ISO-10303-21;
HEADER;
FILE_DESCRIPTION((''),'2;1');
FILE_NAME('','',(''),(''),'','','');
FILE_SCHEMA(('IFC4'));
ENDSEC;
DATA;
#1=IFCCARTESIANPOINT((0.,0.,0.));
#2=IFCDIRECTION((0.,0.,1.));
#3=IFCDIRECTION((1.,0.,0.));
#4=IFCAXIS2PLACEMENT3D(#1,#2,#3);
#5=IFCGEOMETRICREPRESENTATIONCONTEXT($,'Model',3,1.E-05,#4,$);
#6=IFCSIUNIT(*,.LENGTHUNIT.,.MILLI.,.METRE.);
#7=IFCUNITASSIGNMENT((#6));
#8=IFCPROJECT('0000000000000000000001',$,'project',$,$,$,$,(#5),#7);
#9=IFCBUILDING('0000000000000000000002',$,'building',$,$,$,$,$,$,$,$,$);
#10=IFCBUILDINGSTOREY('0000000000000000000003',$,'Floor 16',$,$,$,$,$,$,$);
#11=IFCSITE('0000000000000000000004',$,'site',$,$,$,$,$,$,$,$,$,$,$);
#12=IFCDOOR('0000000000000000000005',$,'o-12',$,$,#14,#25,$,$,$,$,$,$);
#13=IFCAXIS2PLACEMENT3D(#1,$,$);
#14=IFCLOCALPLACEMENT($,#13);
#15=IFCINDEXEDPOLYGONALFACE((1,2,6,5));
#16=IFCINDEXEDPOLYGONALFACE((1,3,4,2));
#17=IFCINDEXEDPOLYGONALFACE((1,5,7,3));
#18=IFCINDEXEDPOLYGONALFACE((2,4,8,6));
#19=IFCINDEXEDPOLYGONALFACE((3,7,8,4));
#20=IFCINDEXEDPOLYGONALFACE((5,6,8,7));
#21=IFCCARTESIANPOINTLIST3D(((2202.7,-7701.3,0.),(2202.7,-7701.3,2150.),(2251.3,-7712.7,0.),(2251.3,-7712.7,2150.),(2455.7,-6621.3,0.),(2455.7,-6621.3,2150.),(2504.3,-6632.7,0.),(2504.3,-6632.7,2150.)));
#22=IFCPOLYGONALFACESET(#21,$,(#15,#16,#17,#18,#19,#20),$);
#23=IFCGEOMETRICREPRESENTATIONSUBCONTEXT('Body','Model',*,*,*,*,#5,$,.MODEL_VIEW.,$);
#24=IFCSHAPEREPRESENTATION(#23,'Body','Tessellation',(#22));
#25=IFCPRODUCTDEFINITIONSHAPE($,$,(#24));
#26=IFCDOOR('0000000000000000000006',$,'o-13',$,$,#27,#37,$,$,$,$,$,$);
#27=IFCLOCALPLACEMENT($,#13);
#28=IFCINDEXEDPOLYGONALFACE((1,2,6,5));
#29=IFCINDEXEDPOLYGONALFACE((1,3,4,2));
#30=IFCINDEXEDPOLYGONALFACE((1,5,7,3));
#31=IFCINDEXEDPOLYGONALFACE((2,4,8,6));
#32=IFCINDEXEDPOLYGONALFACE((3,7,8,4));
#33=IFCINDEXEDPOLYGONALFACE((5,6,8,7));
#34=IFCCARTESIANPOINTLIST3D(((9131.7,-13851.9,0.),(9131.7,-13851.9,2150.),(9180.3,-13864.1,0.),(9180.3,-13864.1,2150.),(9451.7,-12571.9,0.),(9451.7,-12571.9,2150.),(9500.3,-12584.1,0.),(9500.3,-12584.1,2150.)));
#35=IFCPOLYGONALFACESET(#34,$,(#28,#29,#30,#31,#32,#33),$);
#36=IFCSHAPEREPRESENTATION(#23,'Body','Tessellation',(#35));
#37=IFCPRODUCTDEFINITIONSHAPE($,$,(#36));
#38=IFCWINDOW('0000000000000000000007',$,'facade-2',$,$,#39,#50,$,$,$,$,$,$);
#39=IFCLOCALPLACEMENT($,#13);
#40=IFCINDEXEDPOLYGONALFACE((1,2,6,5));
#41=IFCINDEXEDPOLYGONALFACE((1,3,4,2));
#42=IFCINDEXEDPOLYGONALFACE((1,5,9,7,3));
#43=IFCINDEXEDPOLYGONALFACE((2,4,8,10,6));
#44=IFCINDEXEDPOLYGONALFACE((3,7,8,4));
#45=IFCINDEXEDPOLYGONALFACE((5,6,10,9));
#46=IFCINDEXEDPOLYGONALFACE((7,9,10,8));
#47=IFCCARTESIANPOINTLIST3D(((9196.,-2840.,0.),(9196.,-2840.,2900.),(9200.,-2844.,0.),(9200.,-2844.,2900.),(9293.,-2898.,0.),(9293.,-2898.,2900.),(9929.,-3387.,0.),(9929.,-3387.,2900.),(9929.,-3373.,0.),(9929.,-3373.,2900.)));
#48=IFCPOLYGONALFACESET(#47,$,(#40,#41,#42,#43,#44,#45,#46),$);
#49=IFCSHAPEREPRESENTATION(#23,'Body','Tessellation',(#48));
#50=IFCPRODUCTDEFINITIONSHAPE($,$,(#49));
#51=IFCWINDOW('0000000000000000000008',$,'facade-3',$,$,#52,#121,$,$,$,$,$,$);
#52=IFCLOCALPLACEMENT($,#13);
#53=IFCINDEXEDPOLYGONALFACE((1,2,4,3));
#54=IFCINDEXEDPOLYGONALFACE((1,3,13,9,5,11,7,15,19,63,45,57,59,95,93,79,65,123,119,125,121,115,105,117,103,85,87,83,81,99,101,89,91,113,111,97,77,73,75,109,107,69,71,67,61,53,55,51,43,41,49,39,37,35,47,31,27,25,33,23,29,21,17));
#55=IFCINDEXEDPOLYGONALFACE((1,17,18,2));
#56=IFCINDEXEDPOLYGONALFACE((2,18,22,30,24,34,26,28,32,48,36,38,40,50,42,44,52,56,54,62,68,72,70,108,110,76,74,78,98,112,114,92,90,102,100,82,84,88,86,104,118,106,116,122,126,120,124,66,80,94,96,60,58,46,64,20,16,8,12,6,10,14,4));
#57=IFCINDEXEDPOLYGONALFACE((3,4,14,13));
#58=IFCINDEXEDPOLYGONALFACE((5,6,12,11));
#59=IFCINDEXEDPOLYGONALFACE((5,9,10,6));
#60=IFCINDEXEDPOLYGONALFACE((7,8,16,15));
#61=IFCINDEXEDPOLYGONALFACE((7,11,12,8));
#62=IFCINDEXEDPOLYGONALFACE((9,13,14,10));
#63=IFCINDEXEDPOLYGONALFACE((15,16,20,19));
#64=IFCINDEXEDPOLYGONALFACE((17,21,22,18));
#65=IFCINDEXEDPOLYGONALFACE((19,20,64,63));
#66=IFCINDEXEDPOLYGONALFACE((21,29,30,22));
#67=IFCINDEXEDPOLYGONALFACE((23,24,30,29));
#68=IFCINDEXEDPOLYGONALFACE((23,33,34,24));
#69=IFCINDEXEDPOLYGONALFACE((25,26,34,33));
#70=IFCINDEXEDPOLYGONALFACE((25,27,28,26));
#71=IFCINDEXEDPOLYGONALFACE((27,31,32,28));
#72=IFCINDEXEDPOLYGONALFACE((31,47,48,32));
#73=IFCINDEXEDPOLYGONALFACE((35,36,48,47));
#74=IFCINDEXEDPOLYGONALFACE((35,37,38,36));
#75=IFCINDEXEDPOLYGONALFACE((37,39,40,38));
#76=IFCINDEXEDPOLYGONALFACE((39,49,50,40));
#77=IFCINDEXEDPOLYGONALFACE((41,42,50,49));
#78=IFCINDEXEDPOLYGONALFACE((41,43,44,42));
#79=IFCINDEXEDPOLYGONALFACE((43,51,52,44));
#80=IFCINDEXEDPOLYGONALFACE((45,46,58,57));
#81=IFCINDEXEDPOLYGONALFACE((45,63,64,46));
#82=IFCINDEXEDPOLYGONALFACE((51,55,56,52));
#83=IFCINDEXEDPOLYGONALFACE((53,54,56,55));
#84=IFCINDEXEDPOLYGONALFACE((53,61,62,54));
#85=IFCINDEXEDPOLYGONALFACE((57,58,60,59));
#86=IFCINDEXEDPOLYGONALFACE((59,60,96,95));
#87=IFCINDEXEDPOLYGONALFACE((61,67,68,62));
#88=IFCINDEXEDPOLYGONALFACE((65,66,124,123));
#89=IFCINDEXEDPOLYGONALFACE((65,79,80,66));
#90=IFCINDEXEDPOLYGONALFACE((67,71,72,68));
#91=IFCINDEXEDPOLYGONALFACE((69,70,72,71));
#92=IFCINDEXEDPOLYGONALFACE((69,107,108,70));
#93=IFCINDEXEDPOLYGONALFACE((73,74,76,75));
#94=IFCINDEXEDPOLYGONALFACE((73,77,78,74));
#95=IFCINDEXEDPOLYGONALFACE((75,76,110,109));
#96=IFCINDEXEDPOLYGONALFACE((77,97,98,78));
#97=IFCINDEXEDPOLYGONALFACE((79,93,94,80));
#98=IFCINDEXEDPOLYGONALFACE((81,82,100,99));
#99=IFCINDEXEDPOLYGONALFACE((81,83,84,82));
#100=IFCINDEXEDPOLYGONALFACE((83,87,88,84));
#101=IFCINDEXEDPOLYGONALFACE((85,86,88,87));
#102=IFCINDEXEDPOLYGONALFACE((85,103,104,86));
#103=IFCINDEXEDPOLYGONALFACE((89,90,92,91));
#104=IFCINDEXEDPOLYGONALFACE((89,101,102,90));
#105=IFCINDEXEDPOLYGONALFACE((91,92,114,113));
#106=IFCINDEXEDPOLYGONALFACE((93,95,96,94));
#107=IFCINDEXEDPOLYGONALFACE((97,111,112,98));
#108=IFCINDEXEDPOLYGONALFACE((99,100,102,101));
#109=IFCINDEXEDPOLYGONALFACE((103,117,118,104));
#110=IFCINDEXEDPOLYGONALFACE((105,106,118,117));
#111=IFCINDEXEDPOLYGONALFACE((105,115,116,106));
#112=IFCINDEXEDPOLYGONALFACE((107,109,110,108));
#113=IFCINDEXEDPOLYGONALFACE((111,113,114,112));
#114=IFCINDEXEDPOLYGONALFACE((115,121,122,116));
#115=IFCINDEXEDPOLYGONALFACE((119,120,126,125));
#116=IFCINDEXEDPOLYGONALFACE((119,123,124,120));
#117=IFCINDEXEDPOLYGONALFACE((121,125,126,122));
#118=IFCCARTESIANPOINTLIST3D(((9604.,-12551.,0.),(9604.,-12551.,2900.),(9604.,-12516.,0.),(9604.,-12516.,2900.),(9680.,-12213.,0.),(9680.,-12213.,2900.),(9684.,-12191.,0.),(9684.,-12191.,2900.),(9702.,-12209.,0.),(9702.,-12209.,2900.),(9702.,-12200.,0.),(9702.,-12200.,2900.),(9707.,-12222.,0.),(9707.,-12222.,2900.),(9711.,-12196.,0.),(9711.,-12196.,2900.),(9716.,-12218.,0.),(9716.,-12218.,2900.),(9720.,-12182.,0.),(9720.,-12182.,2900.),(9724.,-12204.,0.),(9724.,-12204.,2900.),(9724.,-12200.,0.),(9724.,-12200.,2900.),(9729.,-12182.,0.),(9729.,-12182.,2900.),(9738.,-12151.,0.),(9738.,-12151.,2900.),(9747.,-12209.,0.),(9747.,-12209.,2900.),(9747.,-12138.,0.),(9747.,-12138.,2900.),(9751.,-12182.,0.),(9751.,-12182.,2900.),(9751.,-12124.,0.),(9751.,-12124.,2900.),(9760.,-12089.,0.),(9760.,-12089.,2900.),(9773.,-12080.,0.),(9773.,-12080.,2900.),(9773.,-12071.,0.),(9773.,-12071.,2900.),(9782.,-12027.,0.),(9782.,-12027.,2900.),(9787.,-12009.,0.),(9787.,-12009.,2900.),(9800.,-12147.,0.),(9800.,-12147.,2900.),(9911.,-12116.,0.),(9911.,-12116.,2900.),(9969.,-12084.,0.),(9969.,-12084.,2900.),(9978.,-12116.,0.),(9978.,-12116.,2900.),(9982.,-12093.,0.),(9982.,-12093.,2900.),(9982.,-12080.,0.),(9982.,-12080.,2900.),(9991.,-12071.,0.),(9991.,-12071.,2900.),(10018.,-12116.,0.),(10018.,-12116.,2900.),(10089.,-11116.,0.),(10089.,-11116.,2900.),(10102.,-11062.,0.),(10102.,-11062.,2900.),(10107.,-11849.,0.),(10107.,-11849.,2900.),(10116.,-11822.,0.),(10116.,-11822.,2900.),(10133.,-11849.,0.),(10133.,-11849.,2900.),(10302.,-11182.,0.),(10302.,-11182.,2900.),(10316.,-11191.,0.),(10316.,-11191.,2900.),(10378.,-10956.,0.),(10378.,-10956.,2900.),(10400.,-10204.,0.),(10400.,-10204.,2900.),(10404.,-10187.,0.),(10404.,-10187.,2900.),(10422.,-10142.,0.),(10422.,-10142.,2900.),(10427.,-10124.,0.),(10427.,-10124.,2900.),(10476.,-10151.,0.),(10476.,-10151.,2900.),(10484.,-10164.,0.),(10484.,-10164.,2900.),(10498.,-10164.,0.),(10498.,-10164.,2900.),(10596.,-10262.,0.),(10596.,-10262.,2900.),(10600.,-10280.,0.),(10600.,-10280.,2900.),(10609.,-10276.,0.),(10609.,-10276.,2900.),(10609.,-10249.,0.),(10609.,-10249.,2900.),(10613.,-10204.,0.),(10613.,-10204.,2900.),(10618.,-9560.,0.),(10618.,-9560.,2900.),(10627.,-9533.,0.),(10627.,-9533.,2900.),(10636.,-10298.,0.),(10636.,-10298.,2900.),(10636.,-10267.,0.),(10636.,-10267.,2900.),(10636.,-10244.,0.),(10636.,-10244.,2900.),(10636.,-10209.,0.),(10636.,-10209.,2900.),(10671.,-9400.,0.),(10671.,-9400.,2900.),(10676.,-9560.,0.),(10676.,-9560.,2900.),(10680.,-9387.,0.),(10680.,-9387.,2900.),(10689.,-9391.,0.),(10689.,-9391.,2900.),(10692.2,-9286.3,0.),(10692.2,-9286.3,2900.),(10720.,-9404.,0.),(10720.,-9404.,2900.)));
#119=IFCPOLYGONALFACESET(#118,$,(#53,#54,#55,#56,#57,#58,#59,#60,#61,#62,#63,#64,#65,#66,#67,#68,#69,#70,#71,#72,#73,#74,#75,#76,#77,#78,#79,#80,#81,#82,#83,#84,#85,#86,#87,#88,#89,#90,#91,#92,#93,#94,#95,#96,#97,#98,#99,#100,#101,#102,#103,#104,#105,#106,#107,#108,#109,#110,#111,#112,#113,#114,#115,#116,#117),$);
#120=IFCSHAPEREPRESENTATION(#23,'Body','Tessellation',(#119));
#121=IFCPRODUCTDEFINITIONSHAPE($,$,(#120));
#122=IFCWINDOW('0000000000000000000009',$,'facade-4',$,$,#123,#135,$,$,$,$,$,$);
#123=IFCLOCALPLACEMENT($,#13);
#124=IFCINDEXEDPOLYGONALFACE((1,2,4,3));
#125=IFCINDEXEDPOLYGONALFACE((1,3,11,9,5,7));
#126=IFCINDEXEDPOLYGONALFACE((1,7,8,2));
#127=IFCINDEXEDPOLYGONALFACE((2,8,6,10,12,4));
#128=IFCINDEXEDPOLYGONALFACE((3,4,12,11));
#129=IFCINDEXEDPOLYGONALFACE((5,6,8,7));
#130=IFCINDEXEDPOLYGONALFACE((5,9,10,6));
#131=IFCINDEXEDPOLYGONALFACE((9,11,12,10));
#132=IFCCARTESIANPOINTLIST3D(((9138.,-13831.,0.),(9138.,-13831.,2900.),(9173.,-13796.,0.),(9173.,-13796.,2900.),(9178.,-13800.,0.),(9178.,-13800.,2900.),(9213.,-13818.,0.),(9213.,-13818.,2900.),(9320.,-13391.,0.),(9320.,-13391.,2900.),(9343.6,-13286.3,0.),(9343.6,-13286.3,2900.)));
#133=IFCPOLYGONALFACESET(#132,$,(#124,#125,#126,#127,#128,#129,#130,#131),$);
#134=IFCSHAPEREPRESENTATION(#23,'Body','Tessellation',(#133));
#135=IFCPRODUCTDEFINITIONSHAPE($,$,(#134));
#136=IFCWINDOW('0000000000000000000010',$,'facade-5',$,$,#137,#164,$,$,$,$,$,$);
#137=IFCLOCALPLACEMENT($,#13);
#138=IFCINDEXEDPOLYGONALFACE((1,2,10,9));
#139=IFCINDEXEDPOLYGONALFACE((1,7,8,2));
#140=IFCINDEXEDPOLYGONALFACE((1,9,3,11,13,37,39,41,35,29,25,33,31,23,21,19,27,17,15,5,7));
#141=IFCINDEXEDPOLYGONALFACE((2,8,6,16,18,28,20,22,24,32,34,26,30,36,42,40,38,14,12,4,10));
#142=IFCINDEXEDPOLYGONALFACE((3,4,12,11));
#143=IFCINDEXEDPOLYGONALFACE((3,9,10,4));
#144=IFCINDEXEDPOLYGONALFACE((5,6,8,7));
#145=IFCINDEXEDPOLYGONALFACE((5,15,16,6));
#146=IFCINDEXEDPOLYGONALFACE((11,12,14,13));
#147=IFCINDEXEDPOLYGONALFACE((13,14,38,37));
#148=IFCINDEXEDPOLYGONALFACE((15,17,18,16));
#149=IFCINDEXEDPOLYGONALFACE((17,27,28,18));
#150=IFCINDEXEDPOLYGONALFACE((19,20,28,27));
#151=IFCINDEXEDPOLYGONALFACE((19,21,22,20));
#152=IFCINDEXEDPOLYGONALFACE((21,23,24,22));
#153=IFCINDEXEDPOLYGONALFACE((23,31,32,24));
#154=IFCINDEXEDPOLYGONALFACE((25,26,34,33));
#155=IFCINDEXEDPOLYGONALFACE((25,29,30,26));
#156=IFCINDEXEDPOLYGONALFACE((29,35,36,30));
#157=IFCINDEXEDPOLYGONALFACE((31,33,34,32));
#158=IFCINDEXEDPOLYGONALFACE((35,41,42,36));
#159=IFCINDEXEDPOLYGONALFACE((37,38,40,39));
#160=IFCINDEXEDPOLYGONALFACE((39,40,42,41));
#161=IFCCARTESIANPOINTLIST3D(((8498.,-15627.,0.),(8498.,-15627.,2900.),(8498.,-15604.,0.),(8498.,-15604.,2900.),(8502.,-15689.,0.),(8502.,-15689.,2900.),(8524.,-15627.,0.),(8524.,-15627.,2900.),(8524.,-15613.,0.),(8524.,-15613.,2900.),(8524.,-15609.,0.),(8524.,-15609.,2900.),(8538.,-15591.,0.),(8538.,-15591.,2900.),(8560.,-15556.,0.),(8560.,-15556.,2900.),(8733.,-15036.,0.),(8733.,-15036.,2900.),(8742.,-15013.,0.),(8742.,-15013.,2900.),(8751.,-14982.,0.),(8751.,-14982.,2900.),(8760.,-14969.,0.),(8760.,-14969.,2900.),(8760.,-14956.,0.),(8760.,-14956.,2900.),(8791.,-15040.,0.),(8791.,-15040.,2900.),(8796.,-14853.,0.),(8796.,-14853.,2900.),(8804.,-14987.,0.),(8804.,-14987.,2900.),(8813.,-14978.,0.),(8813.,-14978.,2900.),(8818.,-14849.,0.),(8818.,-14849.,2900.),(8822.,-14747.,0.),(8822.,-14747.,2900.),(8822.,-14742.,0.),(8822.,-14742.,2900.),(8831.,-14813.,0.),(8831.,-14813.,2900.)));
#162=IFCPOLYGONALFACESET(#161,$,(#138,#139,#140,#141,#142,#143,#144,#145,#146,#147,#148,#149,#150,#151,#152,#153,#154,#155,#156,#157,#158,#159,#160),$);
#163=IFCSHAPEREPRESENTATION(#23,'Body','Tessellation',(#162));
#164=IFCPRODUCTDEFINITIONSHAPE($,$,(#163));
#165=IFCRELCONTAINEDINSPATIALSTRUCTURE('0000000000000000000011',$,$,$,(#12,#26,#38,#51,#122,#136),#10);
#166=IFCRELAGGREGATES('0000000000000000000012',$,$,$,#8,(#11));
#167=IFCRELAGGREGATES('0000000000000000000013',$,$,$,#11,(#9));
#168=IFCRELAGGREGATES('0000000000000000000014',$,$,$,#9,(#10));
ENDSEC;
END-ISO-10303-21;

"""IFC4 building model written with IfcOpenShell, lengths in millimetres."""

from ifc_helpers import new_model, si_unit, origin_with_axes, place, context, subcontext, project, spatial, indexed_curve, outline, extrude, element, save


model = new_model("IFC4")

# Units and contexts
model_context = context("Model", 3, precision=1e-05, world=origin_with_axes())
body_context = subcontext(model_context, "Body", "Model", "MODEL_VIEW")
ifc_project = project(units=[si_unit("LENGTHUNIT", "METRE", prefix="MILLI")], contexts=[model_context])

# Site, building, storey
site = spatial("IfcSite", under=ifc_project, Name="site")
building = spatial("IfcBuilding", under=site, Name="building")
storey = spatial("IfcBuildingStorey", under=building, Name="Floor 16")

# Doors
door_1_placement = place(None, origin_with_axes())
element("IfcDoor", 1, at=door_1_placement, inside=storey, Name="o-12", context=body_context, shape_type="SweptSolid", body=[
    extrude(outline(indexed_curve([(2504.3, -6632.7), (2251.3, -7712.7), (2202.7, -7701.3), (2455.7, -6621.3)])), None, (0.0, 0.0, 1.0), 2150.0),
])
door_2_placement = place(None, origin_with_axes())
element("IfcDoor", 2, at=door_2_placement, inside=storey, Name="o-13", context=body_context, shape_type="SweptSolid", body=[
    extrude(outline(indexed_curve([(9500.3, -12584.1), (9180.3, -13864.1), (9131.7, -13851.9), (9451.7, -12571.9)])), None, (0.0, 0.0, 1.0), 2150.0),
])

# Windows
window_1_placement = place(None, origin_with_axes())
element("IfcWindow", 3, at=window_1_placement, inside=storey, Name="facade-2", context=body_context, shape_type="SweptSolid", body=[
    extrude(outline(indexed_curve([(9196.0, -2840.0), (9200.0, -2844.0), (9929.0, -3387.0), (9929.0, -3373.0), (9293.0, -2898.0)])), None, (0.0, 0.0, 1.0), 2900.0),
])
window_2_placement = place(None, origin_with_axes())
element("IfcWindow", 4, at=window_2_placement, inside=storey, Name="facade-3", context=body_context, shape_type="SweptSolid", body=[
    extrude(outline(indexed_curve([(10692.2, -9286.3), (10102.0, -11062.0), (10400.0, -10204.0), (10596.0, -10262.0), (10600.0, -10280.0), (9991.0, -12071.0), (9982.0, -12080.0), (9787.0, -12009.0), (10089.0, -11116.0), (9720.0, -12182.0), (9711.0, -12196.0), (9684.0, -12191.0), (9702.0, -12200.0), (9680.0, -12213.0), (9702.0, -12209.0), (9707.0, -12222.0), (9604.0, -12516.0), (9604.0, -12551.0), (9716.0, -12218.0), (9724.0, -12204.0), (9747.0, -12209.0), (9724.0, -12200.0), (9751.0, -12182.0), (9729.0, -12182.0), (9738.0, -12151.0), (9747.0, -12138.0), (9800.0, -12147.0), (9751.0, -12124.0), (9760.0, -12089.0), (9773.0, -12080.0), (9911.0, -12116.0), (9773.0, -12071.0), (9782.0, -12027.0), (9969.0, -12084.0), (9982.0, -12093.0), (9978.0, -12116.0), (10018.0, -12116.0), (10107.0, -11849.0), (10133.0, -11849.0), (10116.0, -11822.0), (10636.0, -10298.0), (10636.0, -10267.0), (10316.0, -11191.0), (10302.0, -11182.0), (10378.0, -10956.0), (10609.0, -10276.0), (10636.0, -10244.0), (10636.0, -10209.0), (10498.0, -10164.0), (10484.0, -10164.0), (10613.0, -10204.0), (10609.0, -10249.0), (10404.0, -10187.0), (10422.0, -10142.0), (10476.0, -10151.0), (10427.0, -10124.0), (10618.0, -9560.0), (10676.0, -9560.0), (10627.0, -9533.0), (10671.0, -9400.0), (10689.0, -9391.0), (10720.0, -9404.0), (10680.0, -9387.0)])), None, (0.0, 0.0, 1.0), 2900.0),
])
window_3_placement = place(None, origin_with_axes())
element("IfcWindow", 5, at=window_3_placement, inside=storey, Name="facade-4", context=body_context, shape_type="SweptSolid", body=[
    extrude(outline(indexed_curve([(9343.6, -13286.3), (9173.0, -13796.0), (9138.0, -13831.0), (9213.0, -13818.0), (9178.0, -13800.0), (9320.0, -13391.0)])), None, (0.0, 0.0, 1.0), 2900.0),
])
window_4_placement = place(None, origin_with_axes())
element("IfcWindow", 6, at=window_4_placement, inside=storey, Name="facade-5", context=body_context, shape_type="SweptSolid", body=[
    extrude(outline(indexed_curve([(8822.0, -14742.0), (8822.0, -14747.0), (8538.0, -15591.0), (8524.0, -15609.0), (8498.0, -15604.0), (8524.0, -15613.0), (8498.0, -15627.0), (8524.0, -15627.0), (8502.0, -15689.0), (8560.0, -15556.0), (8733.0, -15036.0), (8791.0, -15040.0), (8742.0, -15013.0), (8751.0, -14982.0), (8760.0, -14969.0), (8804.0, -14987.0), (8813.0, -14978.0), (8760.0, -14956.0), (8796.0, -14853.0), (8818.0, -14849.0), (8831.0, -14813.0)])), None, (0.0, 0.0, 1.0), 2900.0),
])

save(model, "model.ifc")
